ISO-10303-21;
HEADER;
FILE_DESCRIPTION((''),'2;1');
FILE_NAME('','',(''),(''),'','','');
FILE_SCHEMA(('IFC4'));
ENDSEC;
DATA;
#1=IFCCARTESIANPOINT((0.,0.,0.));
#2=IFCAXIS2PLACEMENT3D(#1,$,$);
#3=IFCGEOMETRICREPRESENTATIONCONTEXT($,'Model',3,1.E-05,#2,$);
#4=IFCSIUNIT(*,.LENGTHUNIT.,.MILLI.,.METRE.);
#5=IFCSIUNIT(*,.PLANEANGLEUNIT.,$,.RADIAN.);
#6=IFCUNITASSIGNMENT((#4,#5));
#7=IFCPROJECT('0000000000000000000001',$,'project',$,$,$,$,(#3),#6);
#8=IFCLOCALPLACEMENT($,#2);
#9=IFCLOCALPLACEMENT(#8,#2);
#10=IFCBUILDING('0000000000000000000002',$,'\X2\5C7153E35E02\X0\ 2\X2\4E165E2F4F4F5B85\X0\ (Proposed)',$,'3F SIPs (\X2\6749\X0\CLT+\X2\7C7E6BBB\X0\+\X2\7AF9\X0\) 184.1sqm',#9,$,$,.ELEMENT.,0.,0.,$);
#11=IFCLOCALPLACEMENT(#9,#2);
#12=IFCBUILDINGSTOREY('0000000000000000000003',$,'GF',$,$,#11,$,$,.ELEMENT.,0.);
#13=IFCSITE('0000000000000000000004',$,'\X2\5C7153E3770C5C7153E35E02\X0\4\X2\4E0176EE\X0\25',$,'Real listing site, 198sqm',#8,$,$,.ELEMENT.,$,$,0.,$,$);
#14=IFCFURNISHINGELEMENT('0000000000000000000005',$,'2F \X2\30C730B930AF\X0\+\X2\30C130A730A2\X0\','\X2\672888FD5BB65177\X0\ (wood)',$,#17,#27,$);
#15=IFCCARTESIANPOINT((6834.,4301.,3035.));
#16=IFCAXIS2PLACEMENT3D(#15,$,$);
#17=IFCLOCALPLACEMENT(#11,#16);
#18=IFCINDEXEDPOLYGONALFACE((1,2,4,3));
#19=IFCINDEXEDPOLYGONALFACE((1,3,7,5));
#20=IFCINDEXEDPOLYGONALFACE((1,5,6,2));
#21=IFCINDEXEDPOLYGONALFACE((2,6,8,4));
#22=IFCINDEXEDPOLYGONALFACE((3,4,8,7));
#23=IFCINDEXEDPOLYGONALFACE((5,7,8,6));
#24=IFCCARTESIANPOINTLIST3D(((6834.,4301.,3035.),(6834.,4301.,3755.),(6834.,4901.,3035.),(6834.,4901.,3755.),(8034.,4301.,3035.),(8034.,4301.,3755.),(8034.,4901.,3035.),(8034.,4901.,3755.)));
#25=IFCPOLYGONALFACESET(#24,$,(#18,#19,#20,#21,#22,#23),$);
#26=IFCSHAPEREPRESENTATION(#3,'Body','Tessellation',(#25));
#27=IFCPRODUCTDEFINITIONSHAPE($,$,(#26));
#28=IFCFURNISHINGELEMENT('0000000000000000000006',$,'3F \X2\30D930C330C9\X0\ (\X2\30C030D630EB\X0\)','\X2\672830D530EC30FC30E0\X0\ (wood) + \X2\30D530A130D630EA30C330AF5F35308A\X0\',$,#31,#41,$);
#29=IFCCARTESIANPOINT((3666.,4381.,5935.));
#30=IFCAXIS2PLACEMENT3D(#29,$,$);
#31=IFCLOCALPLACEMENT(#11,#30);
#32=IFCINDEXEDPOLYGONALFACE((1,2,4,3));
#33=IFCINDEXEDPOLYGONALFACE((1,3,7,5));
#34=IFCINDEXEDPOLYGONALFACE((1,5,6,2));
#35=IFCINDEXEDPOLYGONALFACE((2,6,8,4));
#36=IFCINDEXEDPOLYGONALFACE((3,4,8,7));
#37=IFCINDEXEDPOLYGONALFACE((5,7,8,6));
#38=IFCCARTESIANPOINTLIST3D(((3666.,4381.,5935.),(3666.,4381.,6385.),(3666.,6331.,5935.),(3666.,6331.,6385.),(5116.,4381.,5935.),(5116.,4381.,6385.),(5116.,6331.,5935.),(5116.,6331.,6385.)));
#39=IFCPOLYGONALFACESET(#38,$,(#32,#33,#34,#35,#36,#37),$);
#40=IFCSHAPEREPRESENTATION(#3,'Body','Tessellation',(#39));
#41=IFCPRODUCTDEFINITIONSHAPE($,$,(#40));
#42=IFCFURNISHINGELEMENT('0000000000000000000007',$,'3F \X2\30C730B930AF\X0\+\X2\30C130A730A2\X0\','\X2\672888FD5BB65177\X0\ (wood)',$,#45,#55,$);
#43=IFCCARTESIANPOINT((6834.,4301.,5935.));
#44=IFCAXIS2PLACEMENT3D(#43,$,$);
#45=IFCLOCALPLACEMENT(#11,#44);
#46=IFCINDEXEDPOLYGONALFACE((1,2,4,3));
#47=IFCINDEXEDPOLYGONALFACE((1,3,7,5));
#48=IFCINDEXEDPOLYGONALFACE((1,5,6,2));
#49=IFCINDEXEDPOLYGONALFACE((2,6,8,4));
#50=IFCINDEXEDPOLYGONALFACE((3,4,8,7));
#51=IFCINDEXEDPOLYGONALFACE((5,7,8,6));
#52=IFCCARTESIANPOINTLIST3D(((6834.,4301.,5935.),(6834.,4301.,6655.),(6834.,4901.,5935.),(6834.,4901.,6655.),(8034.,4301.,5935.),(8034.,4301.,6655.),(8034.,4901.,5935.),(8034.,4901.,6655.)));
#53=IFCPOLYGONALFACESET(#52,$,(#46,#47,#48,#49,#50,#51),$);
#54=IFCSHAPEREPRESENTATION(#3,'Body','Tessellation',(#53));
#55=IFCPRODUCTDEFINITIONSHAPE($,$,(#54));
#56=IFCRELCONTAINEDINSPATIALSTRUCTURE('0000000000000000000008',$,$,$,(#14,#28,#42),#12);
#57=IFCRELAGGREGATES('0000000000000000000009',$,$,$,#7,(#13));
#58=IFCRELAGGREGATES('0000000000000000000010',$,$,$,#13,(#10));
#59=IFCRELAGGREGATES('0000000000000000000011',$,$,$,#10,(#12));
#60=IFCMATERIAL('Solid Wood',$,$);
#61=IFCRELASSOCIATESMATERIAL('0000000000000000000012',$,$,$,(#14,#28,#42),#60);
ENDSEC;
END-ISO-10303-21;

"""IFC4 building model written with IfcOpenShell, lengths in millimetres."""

from ifc_helpers import new_model, si_unit, frame, frame_2d, origin, place, context, project, spatial, rectangle, extrude, material, element, save


model = new_model("IFC4")

# Units and contexts
model_context = context("Model", 3, precision=1e-05, world=origin())
ifc_project = project(units=[si_unit("LENGTHUNIT", "METRE", prefix="MILLI"), si_unit("PLANEANGLEUNIT", "RADIAN")], contexts=[model_context])

# Site, building, storey
site_placement = place(None, origin())
site = spatial("IfcSite", under=ifc_project, at=site_placement, Name="山口県山口市4丁目25", ObjectType="Real listing site, 198sqm", CompositionType="ELEMENT", RefElevation=0.0)
building_placement = place(site_placement, origin())
building = spatial("IfcBuilding", under=site, at=building_placement, Name="山口市 2世帯住宅 (Proposed)", ObjectType="3F SIPs (杉CLT+籾殻+竹) 184.1sqm", CompositionType="ELEMENT", ElevationOfRefHeight=0.0, ElevationOfTerrain=0.0)
storey_placement = place(building_placement, origin())
storey = spatial("IfcBuildingStorey", under=building, at=storey_placement, Name="GF", CompositionType="ELEMENT", Elevation=0.0)

# Shared definitions
ifc_material_1 = material(Name="Solid Wood")

# Furnishing elements
furnishing_1_placement = place(storey_placement, frame((6834.0, 4301.0, 3035.0)))
element("IfcFurnishingElement", 1, at=furnishing_1_placement, inside=storey, material=ifc_material_1, Name="2F デスク+チェア", Description="木製家具 (wood)", context=model_context, shape_type="SweptSolid", body=[
    extrude(rectangle(XDim=1200.0, YDim=600.0, at=frame_2d((600.0, 300.0))), frame((6834.0, 4301.0, 3035.0)), (0.0, 0.0, 1.0), 720.0),
])
furnishing_2_placement = place(storey_placement, frame((3666.0, 4381.0, 5935.0)))
element("IfcFurnishingElement", 2, at=furnishing_2_placement, inside=storey, material=ifc_material_1, Name="3F ベッド (ダブル)", Description="木フレーム (wood) + ファブリック張り", context=model_context, shape_type="SweptSolid", body=[
    extrude(rectangle(XDim=1450.0, YDim=1950.0, at=frame_2d((725.0, 975.0))), frame((3666.0, 4381.0, 5935.0)), (0.0, 0.0, 1.0), 450.0),
])
furnishing_3_placement = place(storey_placement, frame((6834.0, 4301.0, 5935.0)))
element("IfcFurnishingElement", 3, at=furnishing_3_placement, inside=storey, material=ifc_material_1, Name="3F デスク+チェア", Description="木製家具 (wood)", context=model_context, shape_type="SweptSolid", body=[
    extrude(rectangle(XDim=1200.0, YDim=600.0, at=frame_2d((600.0, 300.0))), frame((6834.0, 4301.0, 5935.0)), (0.0, 0.0, 1.0), 720.0),
])

save(model, "model.ifc")
